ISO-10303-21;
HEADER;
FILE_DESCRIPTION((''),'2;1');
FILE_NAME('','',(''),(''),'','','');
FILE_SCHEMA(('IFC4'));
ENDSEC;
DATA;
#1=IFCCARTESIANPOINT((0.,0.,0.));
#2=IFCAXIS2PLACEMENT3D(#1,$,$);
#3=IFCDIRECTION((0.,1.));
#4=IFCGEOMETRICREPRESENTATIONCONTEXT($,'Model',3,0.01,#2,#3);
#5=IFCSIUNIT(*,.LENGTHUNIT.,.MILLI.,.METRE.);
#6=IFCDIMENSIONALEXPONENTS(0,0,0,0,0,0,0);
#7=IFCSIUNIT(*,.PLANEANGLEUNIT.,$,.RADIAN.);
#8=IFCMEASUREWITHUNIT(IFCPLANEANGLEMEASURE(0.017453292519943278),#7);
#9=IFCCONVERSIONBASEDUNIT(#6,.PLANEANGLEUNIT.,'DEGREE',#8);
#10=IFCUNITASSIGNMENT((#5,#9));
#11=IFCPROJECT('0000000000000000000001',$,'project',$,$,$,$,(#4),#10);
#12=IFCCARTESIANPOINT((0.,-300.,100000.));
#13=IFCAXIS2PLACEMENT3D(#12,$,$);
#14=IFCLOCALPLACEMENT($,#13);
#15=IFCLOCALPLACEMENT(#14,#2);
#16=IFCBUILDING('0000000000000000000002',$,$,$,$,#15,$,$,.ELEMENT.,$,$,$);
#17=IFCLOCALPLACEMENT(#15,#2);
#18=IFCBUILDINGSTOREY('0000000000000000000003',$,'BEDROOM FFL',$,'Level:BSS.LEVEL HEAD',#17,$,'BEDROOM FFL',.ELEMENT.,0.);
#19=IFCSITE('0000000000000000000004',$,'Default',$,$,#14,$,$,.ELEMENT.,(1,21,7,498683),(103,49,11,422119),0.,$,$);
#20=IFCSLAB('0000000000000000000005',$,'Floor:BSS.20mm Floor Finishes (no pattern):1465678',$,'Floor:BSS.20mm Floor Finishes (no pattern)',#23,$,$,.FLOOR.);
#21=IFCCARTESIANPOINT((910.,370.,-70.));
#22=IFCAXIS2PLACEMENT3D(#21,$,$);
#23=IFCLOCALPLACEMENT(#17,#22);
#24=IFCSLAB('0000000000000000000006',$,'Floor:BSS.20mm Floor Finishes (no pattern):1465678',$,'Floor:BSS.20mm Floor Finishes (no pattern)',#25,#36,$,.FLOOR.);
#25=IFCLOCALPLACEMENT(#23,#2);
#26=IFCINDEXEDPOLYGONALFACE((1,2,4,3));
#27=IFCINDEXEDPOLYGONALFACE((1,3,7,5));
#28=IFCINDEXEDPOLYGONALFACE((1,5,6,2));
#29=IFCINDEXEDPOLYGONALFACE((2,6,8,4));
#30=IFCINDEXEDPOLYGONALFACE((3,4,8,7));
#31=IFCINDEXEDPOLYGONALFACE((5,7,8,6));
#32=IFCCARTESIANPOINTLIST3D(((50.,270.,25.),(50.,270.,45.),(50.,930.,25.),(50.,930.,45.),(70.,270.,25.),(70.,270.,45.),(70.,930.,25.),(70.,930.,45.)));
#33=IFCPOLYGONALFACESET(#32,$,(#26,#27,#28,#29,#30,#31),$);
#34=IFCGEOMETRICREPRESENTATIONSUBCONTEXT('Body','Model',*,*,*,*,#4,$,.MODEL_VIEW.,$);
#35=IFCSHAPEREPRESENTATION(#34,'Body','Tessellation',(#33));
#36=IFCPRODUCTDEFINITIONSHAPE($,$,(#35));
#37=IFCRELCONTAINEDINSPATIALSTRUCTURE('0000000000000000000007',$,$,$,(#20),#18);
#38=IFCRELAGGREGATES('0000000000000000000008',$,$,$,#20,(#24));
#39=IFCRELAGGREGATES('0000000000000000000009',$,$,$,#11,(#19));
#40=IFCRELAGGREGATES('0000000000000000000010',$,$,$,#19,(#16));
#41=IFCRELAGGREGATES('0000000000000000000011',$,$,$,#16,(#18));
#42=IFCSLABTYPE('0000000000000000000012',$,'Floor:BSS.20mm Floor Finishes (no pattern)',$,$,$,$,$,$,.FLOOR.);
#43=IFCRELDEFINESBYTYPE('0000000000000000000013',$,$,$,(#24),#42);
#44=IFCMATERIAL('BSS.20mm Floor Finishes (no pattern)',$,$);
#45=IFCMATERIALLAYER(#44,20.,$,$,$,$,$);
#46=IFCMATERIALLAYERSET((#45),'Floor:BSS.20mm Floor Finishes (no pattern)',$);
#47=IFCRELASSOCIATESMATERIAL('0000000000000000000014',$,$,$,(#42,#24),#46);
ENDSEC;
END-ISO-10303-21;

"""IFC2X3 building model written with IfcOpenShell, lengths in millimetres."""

from ifc_helpers import new_model, entity, si_unit, converted_unit, direction, frame, frame_2d, origin, place, context, subcontext, project, spatial, rectangle, extrude, material, layer, layer_set, type_object, element, aggregate, save


model = new_model("IFC2X3")

# Units and contexts
model_context = context("Model", 3, precision=0.01, world=origin(), true_north=direction((0.0, 1.0)))
body_context = subcontext(model_context, "Body", "Model", "MODEL_VIEW")
ifc_project = project(units=[si_unit("LENGTHUNIT", "METRE", prefix="MILLI"), converted_unit("PLANEANGLEUNIT", "DEGREE", entity("IfcPlaneAngleMeasure", 0.017453292519943278), si_unit("PLANEANGLEUNIT", "RADIAN"), dimensions=[0, 0, 0, 0, 0, 0, 0])], contexts=[model_context])

# Site, building, storey
site_placement = place(None, frame((0.0, -300.0, 100000.0)))
site = spatial("IfcSite", under=ifc_project, at=site_placement, Name="Default", CompositionType="ELEMENT", RefLatitude=(1, 21, 7, 498683), RefLongitude=(103, 49, 11, 422119), RefElevation=0.0)
building_placement = place(site_placement, origin())
building = spatial("IfcBuilding", under=site, at=building_placement, CompositionType="ELEMENT")
storey_placement = place(building_placement, origin())
storey = spatial("IfcBuildingStorey", under=building, at=storey_placement, Name="BEDROOM FFL", ObjectType="Level:BSS.LEVEL HEAD", LongName="BEDROOM FFL", CompositionType="ELEMENT", Elevation=0.0)

# Slabs
ifc_material_1 = material(Name="BSS.20mm Floor Finishes (no pattern)")
ifc_layer_1 = layer(ifc_material_1, 20.0)
ifc_layer_set_1 = layer_set([ifc_layer_1], Name="Floor:BSS.20mm Floor Finishes (no pattern)")
slab_type_1 = type_object("IfcSlabType", Name="Floor:BSS.20mm Floor Finishes (no pattern)", PredefinedType="FLOOR", material=ifc_layer_set_1)
slab_1_placement = place(storey_placement, frame((910.0, 370.0, -70.0)))
slab_1 = element("IfcSlab", 1, at=slab_1_placement, inside=storey, Name="Floor:BSS.20mm Floor Finishes (no pattern):1465678", ObjectType="Floor:BSS.20mm Floor Finishes (no pattern)", PredefinedType="FLOOR")
slab_2_placement = place(slab_1_placement, origin())
slab_2 = element("IfcSlab", 2, at=slab_2_placement, type_object=slab_type_1, material=ifc_layer_set_1, Name="Floor:BSS.20mm Floor Finishes (no pattern):1465678", ObjectType="Floor:BSS.20mm Floor Finishes (no pattern)", PredefinedType="FLOOR", context=body_context, shape_type="SweptSolid", body=[
    extrude(rectangle(XDim=660.0, YDim=20.0, at=frame_2d((0.0, 0.0), x_axis=(0.0, -1.0))), frame((60.0, 600.0, 45.0)), (0.0, 0.0, -1.0), 20.0),
])
aggregate(slab_1, [slab_2])

save(model, "model.ifc")
